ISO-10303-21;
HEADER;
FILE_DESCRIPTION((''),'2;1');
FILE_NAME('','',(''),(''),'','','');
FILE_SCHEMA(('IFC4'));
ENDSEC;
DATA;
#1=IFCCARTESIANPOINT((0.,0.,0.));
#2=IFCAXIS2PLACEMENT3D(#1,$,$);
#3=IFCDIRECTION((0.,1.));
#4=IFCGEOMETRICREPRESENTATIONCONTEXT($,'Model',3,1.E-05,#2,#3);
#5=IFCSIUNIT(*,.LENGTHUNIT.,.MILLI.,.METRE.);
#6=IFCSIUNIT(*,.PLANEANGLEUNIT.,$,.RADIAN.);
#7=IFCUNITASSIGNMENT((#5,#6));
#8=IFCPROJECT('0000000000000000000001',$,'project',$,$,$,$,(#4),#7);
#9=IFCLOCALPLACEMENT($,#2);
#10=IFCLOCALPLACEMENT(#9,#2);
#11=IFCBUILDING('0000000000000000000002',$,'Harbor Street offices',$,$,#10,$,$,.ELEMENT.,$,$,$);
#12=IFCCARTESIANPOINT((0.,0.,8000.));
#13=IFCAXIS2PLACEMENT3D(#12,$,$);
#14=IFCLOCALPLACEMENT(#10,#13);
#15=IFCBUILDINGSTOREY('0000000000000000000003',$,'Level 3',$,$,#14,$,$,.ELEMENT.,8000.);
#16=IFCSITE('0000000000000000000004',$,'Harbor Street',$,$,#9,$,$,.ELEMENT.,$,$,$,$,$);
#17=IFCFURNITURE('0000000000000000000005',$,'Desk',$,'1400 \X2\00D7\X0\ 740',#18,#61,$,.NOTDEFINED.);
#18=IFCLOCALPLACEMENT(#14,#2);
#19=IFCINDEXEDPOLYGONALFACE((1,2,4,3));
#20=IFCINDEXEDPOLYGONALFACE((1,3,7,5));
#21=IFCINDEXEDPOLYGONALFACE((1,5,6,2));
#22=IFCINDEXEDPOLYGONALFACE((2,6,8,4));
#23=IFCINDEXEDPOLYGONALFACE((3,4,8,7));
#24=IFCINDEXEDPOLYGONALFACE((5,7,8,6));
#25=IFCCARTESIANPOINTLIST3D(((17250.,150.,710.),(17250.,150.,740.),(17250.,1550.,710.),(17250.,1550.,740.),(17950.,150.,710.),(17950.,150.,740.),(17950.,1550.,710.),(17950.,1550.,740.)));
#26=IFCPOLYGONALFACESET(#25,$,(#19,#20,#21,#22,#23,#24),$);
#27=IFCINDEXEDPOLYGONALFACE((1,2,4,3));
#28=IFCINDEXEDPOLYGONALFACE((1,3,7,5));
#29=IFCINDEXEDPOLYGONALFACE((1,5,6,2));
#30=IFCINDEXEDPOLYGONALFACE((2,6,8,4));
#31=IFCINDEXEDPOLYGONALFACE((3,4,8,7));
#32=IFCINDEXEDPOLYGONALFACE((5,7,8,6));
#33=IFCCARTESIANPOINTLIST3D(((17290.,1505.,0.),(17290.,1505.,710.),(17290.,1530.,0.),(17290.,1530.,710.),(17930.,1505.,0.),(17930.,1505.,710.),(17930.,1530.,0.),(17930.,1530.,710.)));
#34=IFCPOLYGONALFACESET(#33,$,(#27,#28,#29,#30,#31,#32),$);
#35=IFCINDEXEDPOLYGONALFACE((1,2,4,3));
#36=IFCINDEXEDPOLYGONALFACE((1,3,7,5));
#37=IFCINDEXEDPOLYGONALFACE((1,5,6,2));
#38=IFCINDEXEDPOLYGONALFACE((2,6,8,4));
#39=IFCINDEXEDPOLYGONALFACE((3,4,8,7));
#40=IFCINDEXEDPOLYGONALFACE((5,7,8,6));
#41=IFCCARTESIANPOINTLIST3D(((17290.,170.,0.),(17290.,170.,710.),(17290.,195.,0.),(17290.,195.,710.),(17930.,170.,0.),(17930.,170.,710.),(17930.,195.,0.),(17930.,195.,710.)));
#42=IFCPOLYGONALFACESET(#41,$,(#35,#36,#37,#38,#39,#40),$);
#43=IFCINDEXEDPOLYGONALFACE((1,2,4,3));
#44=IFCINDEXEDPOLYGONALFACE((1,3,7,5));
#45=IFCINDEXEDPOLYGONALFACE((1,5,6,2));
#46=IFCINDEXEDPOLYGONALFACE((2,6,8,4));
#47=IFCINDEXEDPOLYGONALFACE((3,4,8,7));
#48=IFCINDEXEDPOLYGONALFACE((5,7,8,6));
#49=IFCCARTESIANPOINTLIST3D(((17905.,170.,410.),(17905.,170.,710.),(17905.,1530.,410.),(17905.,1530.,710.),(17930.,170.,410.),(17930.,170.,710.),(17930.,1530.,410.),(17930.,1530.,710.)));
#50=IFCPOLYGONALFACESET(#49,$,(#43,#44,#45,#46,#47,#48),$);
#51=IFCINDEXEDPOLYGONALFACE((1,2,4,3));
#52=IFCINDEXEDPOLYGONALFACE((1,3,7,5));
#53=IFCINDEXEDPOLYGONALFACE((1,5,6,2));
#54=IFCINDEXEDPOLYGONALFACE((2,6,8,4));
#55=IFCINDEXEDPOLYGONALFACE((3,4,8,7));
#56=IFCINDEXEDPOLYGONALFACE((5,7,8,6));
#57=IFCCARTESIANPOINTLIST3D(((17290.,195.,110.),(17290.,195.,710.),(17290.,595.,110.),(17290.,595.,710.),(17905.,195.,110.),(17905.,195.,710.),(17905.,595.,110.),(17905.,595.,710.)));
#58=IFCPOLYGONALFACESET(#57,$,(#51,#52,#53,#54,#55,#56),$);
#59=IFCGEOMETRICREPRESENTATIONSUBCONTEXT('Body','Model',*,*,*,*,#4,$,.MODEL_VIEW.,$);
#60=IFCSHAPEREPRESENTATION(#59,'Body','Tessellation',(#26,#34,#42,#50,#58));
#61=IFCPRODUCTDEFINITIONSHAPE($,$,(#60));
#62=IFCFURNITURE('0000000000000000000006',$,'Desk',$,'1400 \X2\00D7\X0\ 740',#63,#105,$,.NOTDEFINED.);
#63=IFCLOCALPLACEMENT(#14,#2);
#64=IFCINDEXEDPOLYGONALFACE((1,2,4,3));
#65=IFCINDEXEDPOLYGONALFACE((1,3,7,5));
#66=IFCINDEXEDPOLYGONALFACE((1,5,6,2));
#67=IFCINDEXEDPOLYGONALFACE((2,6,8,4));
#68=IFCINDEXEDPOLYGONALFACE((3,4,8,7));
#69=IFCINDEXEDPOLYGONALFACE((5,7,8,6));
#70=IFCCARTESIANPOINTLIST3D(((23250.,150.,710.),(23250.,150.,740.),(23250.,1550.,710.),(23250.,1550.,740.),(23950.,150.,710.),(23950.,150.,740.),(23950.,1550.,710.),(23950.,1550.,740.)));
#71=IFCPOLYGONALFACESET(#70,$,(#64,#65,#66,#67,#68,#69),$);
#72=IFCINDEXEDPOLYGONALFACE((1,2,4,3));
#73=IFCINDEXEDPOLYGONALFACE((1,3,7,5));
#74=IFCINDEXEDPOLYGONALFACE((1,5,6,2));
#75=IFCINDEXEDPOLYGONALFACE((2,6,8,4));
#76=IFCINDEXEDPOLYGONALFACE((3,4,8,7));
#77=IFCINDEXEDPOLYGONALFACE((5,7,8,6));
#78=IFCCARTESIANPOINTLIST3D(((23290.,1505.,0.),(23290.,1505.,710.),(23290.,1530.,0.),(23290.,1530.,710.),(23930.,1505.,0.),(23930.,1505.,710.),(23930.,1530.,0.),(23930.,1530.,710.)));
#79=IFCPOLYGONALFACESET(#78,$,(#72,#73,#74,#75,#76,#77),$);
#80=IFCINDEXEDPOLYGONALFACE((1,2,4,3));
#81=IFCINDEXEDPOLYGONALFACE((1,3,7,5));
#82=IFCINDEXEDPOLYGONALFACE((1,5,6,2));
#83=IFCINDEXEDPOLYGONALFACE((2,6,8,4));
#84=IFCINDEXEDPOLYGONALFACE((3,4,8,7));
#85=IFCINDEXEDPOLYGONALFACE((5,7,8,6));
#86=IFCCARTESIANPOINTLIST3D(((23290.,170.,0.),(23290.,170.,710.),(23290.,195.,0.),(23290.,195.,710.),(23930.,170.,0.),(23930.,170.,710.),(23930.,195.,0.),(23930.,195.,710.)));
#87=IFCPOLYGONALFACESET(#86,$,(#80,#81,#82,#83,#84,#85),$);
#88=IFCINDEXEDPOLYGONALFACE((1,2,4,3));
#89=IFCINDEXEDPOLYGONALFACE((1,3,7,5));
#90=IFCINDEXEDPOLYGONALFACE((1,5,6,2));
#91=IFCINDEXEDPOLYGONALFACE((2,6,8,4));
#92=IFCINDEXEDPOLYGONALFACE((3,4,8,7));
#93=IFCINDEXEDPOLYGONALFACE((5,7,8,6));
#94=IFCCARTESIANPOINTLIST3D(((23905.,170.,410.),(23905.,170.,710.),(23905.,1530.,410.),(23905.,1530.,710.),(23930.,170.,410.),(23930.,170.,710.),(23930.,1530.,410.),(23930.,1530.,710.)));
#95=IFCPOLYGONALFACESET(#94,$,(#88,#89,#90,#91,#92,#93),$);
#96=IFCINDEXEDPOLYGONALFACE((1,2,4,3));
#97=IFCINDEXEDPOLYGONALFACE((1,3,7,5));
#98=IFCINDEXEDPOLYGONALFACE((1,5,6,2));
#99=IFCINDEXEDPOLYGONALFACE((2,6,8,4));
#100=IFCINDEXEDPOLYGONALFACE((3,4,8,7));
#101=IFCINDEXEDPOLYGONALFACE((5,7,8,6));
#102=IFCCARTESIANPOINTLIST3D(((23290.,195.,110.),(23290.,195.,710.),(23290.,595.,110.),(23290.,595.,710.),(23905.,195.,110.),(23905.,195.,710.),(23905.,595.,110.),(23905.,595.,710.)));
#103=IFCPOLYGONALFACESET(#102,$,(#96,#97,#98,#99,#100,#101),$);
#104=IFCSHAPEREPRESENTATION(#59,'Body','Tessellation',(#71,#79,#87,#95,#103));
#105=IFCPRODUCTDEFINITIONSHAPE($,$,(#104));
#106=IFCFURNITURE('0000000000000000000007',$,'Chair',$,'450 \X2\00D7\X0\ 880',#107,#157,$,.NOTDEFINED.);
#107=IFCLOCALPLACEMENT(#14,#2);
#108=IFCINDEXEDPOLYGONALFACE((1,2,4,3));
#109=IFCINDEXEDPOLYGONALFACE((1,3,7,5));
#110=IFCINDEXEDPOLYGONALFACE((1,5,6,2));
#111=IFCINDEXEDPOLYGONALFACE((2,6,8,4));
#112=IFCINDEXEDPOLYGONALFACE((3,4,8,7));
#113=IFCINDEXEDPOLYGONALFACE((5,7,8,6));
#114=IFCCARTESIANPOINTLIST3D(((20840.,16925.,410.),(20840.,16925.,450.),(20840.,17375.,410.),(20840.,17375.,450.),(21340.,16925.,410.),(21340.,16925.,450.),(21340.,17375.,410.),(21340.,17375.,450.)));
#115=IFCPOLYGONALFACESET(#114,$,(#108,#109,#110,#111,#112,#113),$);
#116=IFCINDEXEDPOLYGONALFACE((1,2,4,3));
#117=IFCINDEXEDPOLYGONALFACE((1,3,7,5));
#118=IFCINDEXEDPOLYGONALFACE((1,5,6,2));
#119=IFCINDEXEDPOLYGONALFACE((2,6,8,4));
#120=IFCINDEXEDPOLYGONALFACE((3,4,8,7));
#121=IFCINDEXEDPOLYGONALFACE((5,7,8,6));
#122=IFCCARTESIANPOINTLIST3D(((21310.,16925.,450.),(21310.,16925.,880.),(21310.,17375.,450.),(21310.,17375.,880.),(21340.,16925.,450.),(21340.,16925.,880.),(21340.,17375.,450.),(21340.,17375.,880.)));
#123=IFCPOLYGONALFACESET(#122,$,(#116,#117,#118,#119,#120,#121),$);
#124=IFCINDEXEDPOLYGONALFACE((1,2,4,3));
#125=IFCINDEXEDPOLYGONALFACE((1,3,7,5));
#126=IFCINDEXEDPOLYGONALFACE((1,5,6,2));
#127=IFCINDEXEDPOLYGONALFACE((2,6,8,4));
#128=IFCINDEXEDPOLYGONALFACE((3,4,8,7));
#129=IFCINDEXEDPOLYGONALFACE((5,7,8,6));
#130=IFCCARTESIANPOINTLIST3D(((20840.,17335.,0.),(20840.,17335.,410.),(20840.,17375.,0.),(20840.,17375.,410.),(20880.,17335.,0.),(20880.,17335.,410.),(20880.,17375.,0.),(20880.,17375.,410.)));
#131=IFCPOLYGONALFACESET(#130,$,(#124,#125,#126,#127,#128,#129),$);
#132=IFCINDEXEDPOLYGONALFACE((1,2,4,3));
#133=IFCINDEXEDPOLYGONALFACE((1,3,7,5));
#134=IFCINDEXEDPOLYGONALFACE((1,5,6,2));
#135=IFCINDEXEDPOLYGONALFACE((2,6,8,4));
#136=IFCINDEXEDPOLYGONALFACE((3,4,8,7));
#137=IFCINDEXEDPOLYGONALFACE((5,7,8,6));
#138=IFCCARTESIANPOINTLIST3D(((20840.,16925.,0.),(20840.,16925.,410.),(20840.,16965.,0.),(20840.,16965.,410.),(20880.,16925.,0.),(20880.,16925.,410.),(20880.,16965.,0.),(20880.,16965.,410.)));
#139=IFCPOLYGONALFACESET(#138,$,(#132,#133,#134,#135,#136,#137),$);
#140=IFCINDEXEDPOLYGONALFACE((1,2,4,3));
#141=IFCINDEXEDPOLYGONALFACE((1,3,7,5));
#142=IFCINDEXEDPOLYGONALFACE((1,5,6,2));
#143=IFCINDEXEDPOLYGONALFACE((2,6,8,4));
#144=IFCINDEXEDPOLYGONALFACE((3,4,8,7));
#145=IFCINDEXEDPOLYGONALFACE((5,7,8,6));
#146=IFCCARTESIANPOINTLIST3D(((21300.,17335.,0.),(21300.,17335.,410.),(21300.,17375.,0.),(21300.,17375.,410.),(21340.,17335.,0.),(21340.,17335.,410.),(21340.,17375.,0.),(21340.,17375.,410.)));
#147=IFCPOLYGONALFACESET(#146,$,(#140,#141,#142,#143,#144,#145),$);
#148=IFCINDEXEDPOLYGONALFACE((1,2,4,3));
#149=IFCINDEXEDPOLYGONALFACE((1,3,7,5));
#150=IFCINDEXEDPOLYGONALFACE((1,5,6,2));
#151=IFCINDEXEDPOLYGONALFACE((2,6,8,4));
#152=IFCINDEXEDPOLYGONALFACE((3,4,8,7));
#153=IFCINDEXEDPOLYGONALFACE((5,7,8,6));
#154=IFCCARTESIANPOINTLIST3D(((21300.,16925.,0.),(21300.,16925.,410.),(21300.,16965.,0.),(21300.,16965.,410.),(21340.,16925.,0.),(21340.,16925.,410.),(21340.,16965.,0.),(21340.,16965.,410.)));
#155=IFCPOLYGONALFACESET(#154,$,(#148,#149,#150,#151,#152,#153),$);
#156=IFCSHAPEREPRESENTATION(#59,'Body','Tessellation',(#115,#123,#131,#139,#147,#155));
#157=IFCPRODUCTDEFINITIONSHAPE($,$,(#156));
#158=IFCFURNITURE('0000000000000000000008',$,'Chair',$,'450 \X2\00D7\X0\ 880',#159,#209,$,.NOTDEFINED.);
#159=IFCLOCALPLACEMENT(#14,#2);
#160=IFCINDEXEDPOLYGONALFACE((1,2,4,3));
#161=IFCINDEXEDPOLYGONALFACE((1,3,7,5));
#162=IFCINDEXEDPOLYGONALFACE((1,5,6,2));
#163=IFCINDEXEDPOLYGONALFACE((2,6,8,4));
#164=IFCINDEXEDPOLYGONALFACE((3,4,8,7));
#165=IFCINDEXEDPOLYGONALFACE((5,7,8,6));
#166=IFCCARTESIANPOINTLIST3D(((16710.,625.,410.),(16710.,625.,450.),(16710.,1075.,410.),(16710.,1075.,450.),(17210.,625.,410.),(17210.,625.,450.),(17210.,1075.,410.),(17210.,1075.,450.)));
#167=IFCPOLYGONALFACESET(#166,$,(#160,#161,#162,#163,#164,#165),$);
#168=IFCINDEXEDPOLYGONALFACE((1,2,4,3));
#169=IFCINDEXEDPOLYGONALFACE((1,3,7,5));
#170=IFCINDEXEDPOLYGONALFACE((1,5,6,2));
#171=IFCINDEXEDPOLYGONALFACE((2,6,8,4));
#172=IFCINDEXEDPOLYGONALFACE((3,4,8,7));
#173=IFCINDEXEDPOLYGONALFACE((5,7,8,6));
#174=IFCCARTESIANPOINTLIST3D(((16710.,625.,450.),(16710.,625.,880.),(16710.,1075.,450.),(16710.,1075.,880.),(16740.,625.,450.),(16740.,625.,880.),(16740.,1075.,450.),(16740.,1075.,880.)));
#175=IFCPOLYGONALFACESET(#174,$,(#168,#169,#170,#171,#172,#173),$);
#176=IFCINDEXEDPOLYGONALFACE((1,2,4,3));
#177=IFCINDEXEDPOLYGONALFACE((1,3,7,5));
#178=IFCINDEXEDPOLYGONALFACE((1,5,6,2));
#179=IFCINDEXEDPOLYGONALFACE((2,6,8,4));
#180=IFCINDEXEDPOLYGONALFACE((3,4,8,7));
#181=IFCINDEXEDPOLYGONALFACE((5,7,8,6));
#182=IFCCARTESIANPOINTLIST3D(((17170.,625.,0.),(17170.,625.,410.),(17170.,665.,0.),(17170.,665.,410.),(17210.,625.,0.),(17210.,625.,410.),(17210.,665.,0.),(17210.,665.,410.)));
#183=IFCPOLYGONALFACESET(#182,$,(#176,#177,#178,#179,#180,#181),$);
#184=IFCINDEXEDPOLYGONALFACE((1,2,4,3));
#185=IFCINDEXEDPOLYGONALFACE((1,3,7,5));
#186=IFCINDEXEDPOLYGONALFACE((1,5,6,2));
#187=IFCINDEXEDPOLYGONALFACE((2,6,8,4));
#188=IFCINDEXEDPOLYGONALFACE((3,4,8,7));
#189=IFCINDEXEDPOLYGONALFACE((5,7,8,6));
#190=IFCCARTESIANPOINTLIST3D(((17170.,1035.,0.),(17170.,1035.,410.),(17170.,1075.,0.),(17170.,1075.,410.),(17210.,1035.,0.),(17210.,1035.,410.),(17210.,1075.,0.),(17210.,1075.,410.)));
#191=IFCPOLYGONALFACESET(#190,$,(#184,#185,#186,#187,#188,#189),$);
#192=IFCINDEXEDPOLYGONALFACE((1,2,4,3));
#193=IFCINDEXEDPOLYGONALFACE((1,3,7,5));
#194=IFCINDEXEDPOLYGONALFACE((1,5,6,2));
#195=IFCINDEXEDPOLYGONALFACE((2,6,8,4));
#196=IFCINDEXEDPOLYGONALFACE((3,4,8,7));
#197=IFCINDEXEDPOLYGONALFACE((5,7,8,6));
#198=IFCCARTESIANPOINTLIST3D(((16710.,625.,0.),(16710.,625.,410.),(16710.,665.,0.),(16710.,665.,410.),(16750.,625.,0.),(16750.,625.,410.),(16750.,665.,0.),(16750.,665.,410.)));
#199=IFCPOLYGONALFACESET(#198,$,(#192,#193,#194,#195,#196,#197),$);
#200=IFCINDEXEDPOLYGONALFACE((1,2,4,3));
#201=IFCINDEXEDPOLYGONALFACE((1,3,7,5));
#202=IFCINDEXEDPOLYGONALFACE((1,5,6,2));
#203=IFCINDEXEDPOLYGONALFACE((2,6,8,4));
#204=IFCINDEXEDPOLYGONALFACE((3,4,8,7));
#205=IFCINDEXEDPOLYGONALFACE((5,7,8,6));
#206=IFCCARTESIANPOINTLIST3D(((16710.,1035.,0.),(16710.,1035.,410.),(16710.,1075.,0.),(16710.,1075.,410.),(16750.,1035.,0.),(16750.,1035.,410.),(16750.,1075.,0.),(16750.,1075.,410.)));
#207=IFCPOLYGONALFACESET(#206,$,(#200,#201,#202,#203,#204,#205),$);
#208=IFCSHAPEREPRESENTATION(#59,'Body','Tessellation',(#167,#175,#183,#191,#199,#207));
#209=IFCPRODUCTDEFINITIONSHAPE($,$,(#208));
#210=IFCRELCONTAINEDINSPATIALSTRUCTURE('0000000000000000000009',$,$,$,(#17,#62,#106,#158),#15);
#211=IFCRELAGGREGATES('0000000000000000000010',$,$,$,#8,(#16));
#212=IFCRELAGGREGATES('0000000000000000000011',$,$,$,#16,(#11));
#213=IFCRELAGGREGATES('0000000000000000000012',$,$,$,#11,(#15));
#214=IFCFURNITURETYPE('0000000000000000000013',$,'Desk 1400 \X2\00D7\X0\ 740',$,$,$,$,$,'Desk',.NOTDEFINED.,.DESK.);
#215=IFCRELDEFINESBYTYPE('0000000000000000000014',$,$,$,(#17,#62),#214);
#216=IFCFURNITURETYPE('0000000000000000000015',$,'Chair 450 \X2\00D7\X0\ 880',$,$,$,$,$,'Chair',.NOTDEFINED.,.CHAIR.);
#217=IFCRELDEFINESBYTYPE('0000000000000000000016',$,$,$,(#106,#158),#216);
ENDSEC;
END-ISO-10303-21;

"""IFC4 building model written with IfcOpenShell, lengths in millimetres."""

from ifc_helpers import new_model, si_unit, direction, frame, origin, place, context, subcontext, project, spatial, polyline, outline, extrude, source, transform, mapped, type_object, type_shapes, element, save


model = new_model("IFC4")

# Units and contexts
model_context = context("Model", 3, precision=1e-05, world=origin(), true_north=direction((0.0, 1.0)))
body_context = subcontext(model_context, "Body", "Model", "MODEL_VIEW")
ifc_project = project(units=[si_unit("LENGTHUNIT", "METRE", prefix="MILLI"), si_unit("PLANEANGLEUNIT", "RADIAN")], contexts=[model_context])

# Site, building, storey
site_placement = place(None, origin())
site = spatial("IfcSite", under=ifc_project, at=site_placement, Name="Harbor Street", CompositionType="ELEMENT")
building_placement = place(site_placement, origin())
building = spatial("IfcBuilding", under=site, at=building_placement, Name="Harbor Street offices", CompositionType="ELEMENT")
storey_placement = place(building_placement, frame((0.0, 0.0, 8000.0)))
storey = spatial("IfcBuildingStorey", under=building, at=storey_placement, Name="Level 3", CompositionType="ELEMENT", Elevation=8000.0)

# Furniture
furniture_type_1 = type_object("IfcFurnitureType", Name="Desk 1400 × 740", ElementType="Desk", AssemblyPlace="NOTDEFINED", PredefinedType="DESK")
shared_shape_1 = source(origin(), body_context, "Body", "SweptSolid", [
    extrude(outline(polyline([(-700.0, 0.0), (700.0, 0.0), (700.0, 700.0), (-700.0, 700.0), (-700.0, 0.0)])), frame((0.0, 0.0, 710.0)), (0.0, 0.0, 1.0), 30.0),
    extrude(outline(polyline([(-680.0, 40.0), (-655.0, 40.0), (-655.0, 680.0), (-680.0, 680.0), (-680.0, 40.0)])), origin(), (0.0, 0.0, 1.0), 710.0),
    extrude(outline(polyline([(655.0, 40.0), (680.0, 40.0), (680.0, 680.0), (655.0, 680.0), (655.0, 40.0)])), origin(), (0.0, 0.0, 1.0), 710.0),
    extrude(outline(polyline([(-680.0, 655.0), (680.0, 655.0), (680.0, 680.0), (-680.0, 680.0), (-680.0, 655.0)])), frame((0.0, 0.0, 410.0)), (0.0, 0.0, 1.0), 300.0),
    extrude(outline(polyline([(255.0, 40.0), (655.0, 40.0), (655.0, 655.0), (255.0, 655.0), (255.0, 40.0)])), frame((0.0, 0.0, 110.0)), (0.0, 0.0, 1.0), 600.0),
])
type_shapes(furniture_type_1, [shared_shape_1])
for number, where, z_axis, x_axis, name in (
    (1, (17250.0, 850.0, 0.0), (0.0, 0.0, 1.0), (0.0, -1.0, 0.0), "Desk"),
    (2, (23250.0, 850.0, 0.0), (0.0, 0.0, 1.0), (0.0, -1.0, 0.0), "Desk"),
):
    element("IfcFurniture", number, at=place(storey_placement, frame(where, z_axis=z_axis, x_axis=x_axis)), inside=storey, type_object=furniture_type_1, Name=name, ObjectType="1400 × 740", PredefinedType="NOTDEFINED", context=body_context, shape_type="MappedRepresentation", body=[
        mapped(shared_shape_1, transform((0.0, 0.0, 0.0))),
    ])
furniture_type_2 = type_object("IfcFurnitureType", Name="Chair 450 × 880", ElementType="Chair", AssemblyPlace="NOTDEFINED", PredefinedType="CHAIR")
shared_shape_2 = source(origin(), body_context, "Body", "SweptSolid", [
    extrude(outline(polyline([(-225.0, 0.0), (225.0, 0.0), (225.0, 500.0), (-225.0, 500.0), (-225.0, 0.0)])), frame((0.0, 0.0, 410.0)), (0.0, 0.0, 1.0), 40.0),
    extrude(outline(polyline([(-225.0, 470.0), (225.0, 470.0), (225.0, 500.0), (-225.0, 500.0), (-225.0, 470.0)])), frame((0.0, 0.0, 450.0)), (0.0, 0.0, 1.0), 430.0),
    extrude(outline(polyline([(-225.0, 0.0), (-185.0, 0.0), (-185.0, 40.0), (-225.0, 40.0), (-225.0, 0.0)])), origin(), (0.0, 0.0, 1.0), 410.0),
    extrude(outline(polyline([(185.0, 0.0), (225.0, 0.0), (225.0, 40.0), (185.0, 40.0), (185.0, 0.0)])), origin(), (0.0, 0.0, 1.0), 410.0),
    extrude(outline(polyline([(-225.0, 460.0), (-185.0, 460.0), (-185.0, 500.0), (-225.0, 500.0), (-225.0, 460.0)])), origin(), (0.0, 0.0, 1.0), 410.0),
    extrude(outline(polyline([(185.0, 460.0), (225.0, 460.0), (225.0, 500.0), (185.0, 500.0), (185.0, 460.0)])), origin(), (0.0, 0.0, 1.0), 410.0),
])
type_shapes(furniture_type_2, [shared_shape_2])
for number, where, z_axis, x_axis, name in (
    (3, (20840.0, 17150.0, 0.0), (0.0, 0.0, 1.0), (0.0, -1.0, 0.0), "Chair"),
    (4, (17210.0, 850.0, 0.0), (0.0, 0.0, 1.0), (0.0, 1.0, 0.0), "Chair"),
):
    element("IfcFurniture", number, at=place(storey_placement, frame(where, z_axis=z_axis, x_axis=x_axis)), inside=storey, type_object=furniture_type_2, Name=name, ObjectType="450 × 880", PredefinedType="NOTDEFINED", context=body_context, shape_type="MappedRepresentation", body=[
        mapped(shared_shape_2, transform((0.0, 0.0, 0.0))),
    ])

save(model, "model.ifc")
